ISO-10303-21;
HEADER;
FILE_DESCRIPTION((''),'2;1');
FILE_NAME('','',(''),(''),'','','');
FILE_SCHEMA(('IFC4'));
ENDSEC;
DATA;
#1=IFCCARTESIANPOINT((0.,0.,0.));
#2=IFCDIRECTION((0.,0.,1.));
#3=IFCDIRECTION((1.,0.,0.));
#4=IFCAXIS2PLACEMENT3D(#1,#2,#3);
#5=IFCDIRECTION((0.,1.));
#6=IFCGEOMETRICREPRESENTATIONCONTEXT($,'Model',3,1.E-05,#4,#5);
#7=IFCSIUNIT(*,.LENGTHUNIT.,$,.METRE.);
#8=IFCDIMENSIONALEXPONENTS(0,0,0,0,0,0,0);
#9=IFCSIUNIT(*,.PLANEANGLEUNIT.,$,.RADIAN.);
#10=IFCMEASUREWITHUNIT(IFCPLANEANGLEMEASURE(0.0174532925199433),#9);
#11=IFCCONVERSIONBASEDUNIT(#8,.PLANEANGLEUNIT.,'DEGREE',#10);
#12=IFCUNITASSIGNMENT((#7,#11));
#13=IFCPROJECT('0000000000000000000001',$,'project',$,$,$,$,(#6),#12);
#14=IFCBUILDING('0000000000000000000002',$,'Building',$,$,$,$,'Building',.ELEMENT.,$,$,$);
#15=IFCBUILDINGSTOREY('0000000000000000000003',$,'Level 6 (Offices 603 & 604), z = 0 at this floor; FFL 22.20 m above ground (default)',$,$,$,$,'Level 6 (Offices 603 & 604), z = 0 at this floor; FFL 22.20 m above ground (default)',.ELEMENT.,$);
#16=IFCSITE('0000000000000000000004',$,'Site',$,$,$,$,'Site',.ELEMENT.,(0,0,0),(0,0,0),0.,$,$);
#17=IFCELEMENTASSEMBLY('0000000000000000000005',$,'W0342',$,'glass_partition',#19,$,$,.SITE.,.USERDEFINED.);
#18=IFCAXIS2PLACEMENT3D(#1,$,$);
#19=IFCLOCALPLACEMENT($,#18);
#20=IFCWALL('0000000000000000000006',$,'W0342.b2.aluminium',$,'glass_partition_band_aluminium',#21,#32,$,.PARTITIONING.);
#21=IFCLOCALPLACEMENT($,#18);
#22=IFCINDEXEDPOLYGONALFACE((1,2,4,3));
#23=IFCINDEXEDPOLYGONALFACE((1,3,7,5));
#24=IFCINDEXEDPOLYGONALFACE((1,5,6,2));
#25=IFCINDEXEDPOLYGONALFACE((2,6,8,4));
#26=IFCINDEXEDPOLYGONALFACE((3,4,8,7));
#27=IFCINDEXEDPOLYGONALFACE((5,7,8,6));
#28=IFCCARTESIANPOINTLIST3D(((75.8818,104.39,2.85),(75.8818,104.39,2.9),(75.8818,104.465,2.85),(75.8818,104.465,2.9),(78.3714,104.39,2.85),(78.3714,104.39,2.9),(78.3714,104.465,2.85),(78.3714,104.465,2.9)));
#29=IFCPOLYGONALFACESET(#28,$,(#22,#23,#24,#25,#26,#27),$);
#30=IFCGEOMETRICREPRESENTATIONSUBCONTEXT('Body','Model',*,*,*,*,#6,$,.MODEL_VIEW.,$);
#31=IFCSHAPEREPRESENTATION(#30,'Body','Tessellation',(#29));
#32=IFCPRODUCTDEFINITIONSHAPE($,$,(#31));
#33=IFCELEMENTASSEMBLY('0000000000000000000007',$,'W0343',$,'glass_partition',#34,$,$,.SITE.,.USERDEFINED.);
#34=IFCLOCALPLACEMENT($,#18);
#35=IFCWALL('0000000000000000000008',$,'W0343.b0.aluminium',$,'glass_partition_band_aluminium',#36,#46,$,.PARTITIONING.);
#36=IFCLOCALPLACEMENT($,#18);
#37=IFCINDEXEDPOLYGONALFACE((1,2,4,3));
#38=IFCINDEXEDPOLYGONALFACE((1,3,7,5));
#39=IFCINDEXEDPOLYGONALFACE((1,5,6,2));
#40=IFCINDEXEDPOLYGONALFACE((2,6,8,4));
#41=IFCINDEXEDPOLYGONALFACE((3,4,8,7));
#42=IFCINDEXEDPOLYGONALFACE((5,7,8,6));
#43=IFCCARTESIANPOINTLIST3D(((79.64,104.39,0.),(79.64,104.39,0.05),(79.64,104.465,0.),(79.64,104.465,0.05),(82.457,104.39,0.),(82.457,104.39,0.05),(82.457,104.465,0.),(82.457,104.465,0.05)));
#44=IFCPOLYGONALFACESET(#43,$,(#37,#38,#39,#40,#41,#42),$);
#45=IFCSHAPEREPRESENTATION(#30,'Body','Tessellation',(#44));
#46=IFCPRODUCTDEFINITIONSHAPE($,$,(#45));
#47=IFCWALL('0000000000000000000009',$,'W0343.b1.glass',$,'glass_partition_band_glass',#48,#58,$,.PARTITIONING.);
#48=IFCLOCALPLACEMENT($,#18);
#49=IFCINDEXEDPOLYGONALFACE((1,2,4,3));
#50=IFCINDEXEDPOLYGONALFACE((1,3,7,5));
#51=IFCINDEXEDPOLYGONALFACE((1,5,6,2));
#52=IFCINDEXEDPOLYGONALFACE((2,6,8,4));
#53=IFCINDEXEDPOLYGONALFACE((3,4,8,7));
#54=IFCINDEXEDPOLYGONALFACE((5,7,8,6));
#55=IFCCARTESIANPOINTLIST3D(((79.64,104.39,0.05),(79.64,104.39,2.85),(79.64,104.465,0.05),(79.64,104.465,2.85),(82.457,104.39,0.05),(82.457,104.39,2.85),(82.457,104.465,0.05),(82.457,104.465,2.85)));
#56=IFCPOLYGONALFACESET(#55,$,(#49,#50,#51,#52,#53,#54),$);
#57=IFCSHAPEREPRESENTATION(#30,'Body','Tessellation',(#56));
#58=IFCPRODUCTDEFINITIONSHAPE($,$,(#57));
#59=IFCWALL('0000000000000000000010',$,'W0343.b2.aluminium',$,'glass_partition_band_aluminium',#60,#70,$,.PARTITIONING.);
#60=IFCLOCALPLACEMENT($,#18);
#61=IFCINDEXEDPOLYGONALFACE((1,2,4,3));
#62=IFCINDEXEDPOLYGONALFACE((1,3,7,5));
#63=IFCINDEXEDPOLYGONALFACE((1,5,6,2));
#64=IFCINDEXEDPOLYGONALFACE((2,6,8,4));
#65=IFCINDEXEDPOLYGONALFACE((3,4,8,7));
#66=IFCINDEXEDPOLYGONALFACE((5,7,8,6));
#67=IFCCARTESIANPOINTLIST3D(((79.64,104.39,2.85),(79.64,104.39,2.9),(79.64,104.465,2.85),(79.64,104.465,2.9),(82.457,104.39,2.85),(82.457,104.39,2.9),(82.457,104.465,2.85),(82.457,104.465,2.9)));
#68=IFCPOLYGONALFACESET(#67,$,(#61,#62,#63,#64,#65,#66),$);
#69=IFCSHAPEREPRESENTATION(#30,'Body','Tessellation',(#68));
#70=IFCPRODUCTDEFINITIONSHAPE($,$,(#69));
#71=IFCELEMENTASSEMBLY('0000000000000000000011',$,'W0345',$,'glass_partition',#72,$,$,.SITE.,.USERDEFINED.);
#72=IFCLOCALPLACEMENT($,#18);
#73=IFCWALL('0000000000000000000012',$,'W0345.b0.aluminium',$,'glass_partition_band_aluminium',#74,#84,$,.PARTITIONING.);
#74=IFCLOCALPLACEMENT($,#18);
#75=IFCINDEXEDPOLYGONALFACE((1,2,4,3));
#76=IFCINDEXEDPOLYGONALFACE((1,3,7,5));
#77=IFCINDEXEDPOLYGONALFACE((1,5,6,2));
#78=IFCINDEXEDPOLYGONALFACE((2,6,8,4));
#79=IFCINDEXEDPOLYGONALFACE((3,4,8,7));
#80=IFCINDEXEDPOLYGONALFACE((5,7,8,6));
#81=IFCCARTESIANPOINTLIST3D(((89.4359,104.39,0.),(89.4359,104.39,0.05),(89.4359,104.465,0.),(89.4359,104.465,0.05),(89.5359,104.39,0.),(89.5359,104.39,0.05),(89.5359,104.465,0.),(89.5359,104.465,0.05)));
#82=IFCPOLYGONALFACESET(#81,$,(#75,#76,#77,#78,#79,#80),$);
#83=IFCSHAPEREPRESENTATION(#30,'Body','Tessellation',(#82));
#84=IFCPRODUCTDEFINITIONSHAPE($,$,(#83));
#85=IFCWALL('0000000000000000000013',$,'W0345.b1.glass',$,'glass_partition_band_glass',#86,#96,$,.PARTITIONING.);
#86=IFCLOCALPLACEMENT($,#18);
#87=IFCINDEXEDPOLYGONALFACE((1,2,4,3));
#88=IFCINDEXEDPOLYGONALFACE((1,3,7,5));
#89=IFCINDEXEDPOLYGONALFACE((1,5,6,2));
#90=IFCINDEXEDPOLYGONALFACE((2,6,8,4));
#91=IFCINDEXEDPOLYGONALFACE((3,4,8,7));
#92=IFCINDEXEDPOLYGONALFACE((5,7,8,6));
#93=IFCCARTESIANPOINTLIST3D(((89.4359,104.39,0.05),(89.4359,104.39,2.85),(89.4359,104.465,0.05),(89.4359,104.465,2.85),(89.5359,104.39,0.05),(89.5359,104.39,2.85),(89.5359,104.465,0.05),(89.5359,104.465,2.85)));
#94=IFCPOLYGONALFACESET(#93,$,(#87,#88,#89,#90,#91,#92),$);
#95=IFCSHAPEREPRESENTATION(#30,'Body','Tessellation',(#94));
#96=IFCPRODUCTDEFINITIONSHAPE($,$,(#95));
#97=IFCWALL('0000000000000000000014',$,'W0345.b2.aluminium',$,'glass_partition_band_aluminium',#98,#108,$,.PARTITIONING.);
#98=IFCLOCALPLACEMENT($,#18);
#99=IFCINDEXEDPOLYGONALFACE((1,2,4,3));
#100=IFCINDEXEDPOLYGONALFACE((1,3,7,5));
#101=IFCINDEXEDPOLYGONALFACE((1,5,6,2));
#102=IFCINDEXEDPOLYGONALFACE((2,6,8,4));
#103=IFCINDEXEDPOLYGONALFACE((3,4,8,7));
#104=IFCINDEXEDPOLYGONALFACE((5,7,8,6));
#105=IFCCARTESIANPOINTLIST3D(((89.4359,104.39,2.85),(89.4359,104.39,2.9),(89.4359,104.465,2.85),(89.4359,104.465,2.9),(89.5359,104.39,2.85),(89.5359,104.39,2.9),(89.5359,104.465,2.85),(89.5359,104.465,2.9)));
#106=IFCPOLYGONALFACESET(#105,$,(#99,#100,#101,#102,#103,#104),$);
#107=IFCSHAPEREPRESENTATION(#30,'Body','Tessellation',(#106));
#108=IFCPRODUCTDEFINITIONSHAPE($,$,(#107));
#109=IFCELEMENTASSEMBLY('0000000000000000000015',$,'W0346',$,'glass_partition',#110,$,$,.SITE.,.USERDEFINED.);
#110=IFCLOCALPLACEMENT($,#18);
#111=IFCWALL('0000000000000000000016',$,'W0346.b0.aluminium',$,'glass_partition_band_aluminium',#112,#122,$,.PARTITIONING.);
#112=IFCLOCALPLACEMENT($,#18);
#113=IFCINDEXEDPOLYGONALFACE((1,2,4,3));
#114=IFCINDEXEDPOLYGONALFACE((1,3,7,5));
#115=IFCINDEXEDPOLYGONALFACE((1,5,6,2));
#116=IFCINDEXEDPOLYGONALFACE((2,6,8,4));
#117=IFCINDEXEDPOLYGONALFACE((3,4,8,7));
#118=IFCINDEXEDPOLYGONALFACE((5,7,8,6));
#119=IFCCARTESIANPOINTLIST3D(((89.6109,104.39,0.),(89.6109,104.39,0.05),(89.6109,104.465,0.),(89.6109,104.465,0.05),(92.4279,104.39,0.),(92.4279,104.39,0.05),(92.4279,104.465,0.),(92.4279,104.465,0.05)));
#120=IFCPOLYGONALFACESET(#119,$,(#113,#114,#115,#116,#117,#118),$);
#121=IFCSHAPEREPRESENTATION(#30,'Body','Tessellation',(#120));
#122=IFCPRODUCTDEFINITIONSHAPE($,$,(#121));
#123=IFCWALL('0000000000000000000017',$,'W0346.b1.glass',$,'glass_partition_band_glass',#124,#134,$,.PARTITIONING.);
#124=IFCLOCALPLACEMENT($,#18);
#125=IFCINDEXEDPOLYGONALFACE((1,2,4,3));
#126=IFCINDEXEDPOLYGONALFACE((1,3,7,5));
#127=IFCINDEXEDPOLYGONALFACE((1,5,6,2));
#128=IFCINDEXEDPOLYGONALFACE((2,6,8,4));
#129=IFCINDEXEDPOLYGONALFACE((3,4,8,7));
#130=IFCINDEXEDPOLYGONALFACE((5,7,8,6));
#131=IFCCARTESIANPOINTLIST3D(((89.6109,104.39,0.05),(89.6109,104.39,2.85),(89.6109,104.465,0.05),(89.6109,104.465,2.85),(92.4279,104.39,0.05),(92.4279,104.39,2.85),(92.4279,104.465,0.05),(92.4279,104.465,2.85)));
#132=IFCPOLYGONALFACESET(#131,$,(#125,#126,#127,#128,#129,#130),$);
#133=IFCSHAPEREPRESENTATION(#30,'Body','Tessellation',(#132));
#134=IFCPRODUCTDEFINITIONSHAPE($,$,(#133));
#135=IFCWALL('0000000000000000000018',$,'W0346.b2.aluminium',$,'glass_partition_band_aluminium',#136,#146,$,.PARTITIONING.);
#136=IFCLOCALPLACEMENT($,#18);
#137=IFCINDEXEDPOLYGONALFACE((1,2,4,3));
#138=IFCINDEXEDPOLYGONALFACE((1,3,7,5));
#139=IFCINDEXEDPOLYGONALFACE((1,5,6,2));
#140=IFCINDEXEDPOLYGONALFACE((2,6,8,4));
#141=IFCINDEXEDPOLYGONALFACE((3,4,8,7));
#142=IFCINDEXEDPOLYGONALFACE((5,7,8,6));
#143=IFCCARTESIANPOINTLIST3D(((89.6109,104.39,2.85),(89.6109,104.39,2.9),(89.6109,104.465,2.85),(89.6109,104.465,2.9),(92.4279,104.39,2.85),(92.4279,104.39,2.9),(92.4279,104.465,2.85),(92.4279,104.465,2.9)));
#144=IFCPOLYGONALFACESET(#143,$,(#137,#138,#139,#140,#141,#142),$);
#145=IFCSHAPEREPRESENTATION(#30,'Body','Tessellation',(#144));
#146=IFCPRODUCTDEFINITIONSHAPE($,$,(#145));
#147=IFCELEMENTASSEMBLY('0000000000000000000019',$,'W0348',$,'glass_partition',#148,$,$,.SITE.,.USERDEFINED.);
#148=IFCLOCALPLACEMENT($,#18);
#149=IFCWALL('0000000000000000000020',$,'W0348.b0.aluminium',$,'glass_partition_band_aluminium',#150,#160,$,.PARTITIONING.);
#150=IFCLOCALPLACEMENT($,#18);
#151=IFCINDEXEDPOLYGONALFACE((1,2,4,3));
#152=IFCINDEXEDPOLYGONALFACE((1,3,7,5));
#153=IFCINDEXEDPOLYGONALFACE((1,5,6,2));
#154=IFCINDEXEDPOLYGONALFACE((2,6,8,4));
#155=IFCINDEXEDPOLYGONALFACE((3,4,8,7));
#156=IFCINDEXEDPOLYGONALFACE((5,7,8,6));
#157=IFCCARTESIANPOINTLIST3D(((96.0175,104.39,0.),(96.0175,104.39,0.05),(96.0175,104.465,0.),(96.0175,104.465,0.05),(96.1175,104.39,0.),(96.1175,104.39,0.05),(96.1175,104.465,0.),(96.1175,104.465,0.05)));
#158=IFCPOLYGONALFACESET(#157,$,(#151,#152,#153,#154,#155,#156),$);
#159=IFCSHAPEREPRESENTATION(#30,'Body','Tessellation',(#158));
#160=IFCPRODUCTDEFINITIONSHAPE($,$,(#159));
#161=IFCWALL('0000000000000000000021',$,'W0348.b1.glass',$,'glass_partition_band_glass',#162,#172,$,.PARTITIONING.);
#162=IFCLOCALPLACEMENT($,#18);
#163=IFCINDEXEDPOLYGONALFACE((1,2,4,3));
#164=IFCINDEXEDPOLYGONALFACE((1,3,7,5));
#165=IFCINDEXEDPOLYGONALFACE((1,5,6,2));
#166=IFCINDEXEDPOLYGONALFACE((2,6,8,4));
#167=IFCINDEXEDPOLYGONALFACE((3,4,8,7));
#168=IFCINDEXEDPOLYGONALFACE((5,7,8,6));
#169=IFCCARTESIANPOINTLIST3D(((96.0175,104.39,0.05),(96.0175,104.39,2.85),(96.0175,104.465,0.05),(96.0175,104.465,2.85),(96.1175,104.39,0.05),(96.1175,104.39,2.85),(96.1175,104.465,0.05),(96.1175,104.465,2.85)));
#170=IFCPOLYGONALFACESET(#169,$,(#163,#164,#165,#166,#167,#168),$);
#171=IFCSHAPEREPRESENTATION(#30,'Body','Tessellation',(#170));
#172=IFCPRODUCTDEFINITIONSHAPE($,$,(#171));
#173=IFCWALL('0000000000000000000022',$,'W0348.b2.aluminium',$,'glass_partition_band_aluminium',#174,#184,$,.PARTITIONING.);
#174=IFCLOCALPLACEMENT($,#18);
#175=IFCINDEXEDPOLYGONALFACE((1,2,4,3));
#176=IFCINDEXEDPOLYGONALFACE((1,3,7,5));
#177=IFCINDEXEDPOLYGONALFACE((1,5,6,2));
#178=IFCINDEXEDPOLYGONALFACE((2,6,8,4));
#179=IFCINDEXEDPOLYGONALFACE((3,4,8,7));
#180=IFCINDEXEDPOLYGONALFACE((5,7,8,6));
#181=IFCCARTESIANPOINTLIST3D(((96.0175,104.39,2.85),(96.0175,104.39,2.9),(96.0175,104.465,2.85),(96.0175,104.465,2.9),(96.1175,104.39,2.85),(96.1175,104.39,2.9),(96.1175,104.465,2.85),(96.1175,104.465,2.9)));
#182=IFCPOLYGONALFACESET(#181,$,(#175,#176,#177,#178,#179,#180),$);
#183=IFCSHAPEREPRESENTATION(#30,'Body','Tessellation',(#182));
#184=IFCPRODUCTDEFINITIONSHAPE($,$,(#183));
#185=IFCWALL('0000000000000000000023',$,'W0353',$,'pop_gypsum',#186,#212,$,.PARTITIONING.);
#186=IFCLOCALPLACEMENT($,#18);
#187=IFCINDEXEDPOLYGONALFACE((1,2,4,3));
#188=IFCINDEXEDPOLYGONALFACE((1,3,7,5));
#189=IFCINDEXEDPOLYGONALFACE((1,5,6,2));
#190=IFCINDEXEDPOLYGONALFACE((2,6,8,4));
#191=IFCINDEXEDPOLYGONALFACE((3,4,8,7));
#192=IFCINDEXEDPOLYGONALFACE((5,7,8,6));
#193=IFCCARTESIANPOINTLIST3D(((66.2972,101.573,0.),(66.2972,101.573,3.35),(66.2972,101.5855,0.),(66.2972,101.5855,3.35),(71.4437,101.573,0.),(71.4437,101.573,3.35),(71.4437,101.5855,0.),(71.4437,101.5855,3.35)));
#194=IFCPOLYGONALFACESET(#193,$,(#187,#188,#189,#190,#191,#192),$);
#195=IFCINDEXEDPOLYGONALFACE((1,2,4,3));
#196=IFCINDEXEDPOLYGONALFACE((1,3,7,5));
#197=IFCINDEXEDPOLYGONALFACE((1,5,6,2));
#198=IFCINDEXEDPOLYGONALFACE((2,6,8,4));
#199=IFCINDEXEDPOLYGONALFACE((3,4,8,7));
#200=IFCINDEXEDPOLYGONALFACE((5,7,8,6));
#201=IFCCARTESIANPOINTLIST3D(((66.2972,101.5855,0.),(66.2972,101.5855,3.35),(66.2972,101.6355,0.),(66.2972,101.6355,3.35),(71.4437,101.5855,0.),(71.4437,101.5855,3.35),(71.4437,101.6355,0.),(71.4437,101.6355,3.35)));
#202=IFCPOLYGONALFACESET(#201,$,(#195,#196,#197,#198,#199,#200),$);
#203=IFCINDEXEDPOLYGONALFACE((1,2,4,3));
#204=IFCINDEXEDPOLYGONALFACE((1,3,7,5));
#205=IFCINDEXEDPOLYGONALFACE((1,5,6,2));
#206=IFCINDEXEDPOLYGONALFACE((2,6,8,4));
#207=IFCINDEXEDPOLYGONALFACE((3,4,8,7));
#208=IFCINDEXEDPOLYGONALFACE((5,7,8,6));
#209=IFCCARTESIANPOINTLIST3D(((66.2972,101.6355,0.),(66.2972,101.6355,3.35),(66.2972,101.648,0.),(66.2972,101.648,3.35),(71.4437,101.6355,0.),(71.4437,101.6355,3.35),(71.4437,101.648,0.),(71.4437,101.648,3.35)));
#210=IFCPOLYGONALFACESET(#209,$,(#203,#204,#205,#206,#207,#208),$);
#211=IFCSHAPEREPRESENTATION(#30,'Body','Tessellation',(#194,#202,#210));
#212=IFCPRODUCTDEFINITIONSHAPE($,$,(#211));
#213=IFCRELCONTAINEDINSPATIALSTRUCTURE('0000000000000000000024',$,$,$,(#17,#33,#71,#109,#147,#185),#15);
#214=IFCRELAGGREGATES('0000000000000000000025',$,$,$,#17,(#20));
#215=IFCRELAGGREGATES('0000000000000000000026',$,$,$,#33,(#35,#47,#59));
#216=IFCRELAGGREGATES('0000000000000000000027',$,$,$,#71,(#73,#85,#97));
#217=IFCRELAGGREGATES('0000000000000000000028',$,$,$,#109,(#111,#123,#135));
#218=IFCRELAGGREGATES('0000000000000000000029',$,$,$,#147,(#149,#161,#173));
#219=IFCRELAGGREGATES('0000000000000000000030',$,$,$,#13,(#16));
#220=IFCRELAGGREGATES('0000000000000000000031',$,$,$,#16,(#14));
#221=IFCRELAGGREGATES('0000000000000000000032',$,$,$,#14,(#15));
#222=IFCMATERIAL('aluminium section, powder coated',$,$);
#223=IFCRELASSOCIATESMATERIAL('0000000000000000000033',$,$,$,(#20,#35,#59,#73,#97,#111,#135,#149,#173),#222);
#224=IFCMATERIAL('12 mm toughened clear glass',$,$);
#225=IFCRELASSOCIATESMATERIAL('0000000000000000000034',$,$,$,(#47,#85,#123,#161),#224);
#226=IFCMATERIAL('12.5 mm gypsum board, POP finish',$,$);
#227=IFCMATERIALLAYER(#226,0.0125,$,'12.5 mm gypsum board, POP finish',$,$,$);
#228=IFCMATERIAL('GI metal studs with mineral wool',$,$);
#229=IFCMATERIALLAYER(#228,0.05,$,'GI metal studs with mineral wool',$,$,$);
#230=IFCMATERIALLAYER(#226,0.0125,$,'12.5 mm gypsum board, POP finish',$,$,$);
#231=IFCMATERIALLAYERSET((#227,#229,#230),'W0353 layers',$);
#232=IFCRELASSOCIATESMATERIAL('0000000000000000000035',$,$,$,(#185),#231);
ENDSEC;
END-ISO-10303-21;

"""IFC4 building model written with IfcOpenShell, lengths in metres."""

from ifc_helpers import new_model, entity, si_unit, converted_unit, direction, frame, frame_2d, origin_with_axes, place, context, subcontext, project, spatial, rectangle, extrude, material, layer, layer_set, layer_usage, element, aggregate, save


model = new_model("IFC4")

# Units and contexts
model_context = context("Model", 3, precision=1e-05, world=origin_with_axes(), true_north=direction((0.0, 1.0)))
body_context = subcontext(model_context, "Body", "Model", "MODEL_VIEW")
ifc_project = project(units=[si_unit("LENGTHUNIT", "METRE"), converted_unit("PLANEANGLEUNIT", "DEGREE", entity("IfcPlaneAngleMeasure", 0.0174532925199433), si_unit("PLANEANGLEUNIT", "RADIAN"), dimensions=[0, 0, 0, 0, 0, 0, 0])], contexts=[model_context])

# Site, building, storey
site = spatial("IfcSite", under=ifc_project, Name="Site", LongName="Site", CompositionType="ELEMENT", RefLatitude=(0, 0, 0), RefLongitude=(0, 0, 0), RefElevation=0.0)
building = spatial("IfcBuilding", under=site, Name="Building", LongName="Building", CompositionType="ELEMENT")
storey = spatial("IfcBuildingStorey", under=building, Name="Level 6 (Offices 603 & 604), z = 0 at this floor; FFL 22.20 m above ground (default)", LongName="Level 6 (Offices 603 & 604), z = 0 at this floor; FFL 22.20 m above ground (default)", CompositionType="ELEMENT")

# Element assembly, wall
assembly_1 = element("IfcElementAssembly", 1, inside=storey, Name="W0342", ObjectType="glass_partition", AssemblyPlace="SITE", PredefinedType="USERDEFINED")
ifc_material_1 = material(Name="aluminium section, powder coated")
placement = place(None, origin_with_axes())
wall_1 = element("IfcWall", 2, at=placement, material=ifc_material_1, Name="W0342.b2.aluminium", ObjectType="glass_partition_band_aluminium", PredefinedType="PARTITIONING", context=body_context, shape_type="SweptSolid", body=[
    extrude(rectangle(XDim=2.4896, YDim=0.075, at=frame_2d((0.0, 0.0), x_axis=(1.0, 0.0))), frame((77.1266, 104.4275, 2.85), z_axis=(0.0, 0.0, 1.0), x_axis=(1.0, 0.0, 0.0)), (0.0, 0.0, 1.0), 0.05),
])
aggregate(assembly_1, [wall_1])

# Element assemblies, walls
assembly_2 = element("IfcElementAssembly", 3, inside=storey, Name="W0343", ObjectType="glass_partition", AssemblyPlace="SITE", PredefinedType="USERDEFINED")
wall_2 = element("IfcWall", 4, at=placement, material=ifc_material_1, Name="W0343.b0.aluminium", ObjectType="glass_partition_band_aluminium", PredefinedType="PARTITIONING", context=body_context, shape_type="SweptSolid", body=[
    extrude(rectangle(XDim=2.817, YDim=0.075, at=frame_2d((0.0, 0.0), x_axis=(1.0, 0.0))), frame((81.0485, 104.4275, 0.0), z_axis=(0.0, 0.0, 1.0), x_axis=(1.0, 0.0, 0.0)), (0.0, 0.0, 1.0), 0.05),
])
ifc_material_2 = material(Name="12 mm toughened clear glass")
wall_3 = element("IfcWall", 5, at=placement, material=ifc_material_2, Name="W0343.b1.glass", ObjectType="glass_partition_band_glass", PredefinedType="PARTITIONING", context=body_context, shape_type="SweptSolid", body=[
    extrude(rectangle(XDim=2.817, YDim=0.075, at=frame_2d((0.0, 0.0), x_axis=(1.0, 0.0))), frame((81.0485, 104.4275, 0.05), z_axis=(0.0, 0.0, 1.0), x_axis=(1.0, 0.0, 0.0)), (0.0, 0.0, 1.0), 2.8),
])
wall_4 = element("IfcWall", 6, at=placement, material=ifc_material_1, Name="W0343.b2.aluminium", ObjectType="glass_partition_band_aluminium", PredefinedType="PARTITIONING", context=body_context, shape_type="SweptSolid", body=[
    extrude(rectangle(XDim=2.817, YDim=0.075, at=frame_2d((0.0, 0.0), x_axis=(1.0, 0.0))), frame((81.0485, 104.4275, 2.85), z_axis=(0.0, 0.0, 1.0), x_axis=(1.0, 0.0, 0.0)), (0.0, 0.0, 1.0), 0.05),
])
aggregate(assembly_2, [wall_2, wall_3, wall_4])
assembly_3 = element("IfcElementAssembly", 7, inside=storey, Name="W0345", ObjectType="glass_partition", AssemblyPlace="SITE", PredefinedType="USERDEFINED")
wall_5 = element("IfcWall", 8, at=placement, material=ifc_material_1, Name="W0345.b0.aluminium", ObjectType="glass_partition_band_aluminium", PredefinedType="PARTITIONING", context=body_context, shape_type="SweptSolid", body=[
    extrude(rectangle(XDim=0.1, YDim=0.075, at=frame_2d((0.0, 0.0), x_axis=(1.0, 0.0))), frame((89.4859, 104.4275, 0.0), z_axis=(0.0, 0.0, 1.0), x_axis=(1.0, 0.0, 0.0)), (0.0, 0.0, 1.0), 0.05),
])
wall_6 = element("IfcWall", 9, at=placement, material=ifc_material_2, Name="W0345.b1.glass", ObjectType="glass_partition_band_glass", PredefinedType="PARTITIONING", context=body_context, shape_type="SweptSolid", body=[
    extrude(rectangle(XDim=0.1, YDim=0.075, at=frame_2d((0.0, 0.0), x_axis=(1.0, 0.0))), frame((89.4859, 104.4275, 0.05), z_axis=(0.0, 0.0, 1.0), x_axis=(1.0, 0.0, 0.0)), (0.0, 0.0, 1.0), 2.8),
])
wall_7 = element("IfcWall", 10, at=placement, material=ifc_material_1, Name="W0345.b2.aluminium", ObjectType="glass_partition_band_aluminium", PredefinedType="PARTITIONING", context=body_context, shape_type="SweptSolid", body=[
    extrude(rectangle(XDim=0.1, YDim=0.075, at=frame_2d((0.0, 0.0), x_axis=(1.0, 0.0))), frame((89.4859, 104.4275, 2.85), z_axis=(0.0, 0.0, 1.0), x_axis=(1.0, 0.0, 0.0)), (0.0, 0.0, 1.0), 0.05),
])
aggregate(assembly_3, [wall_5, wall_6, wall_7])
assembly_4 = element("IfcElementAssembly", 11, inside=storey, Name="W0346", ObjectType="glass_partition", AssemblyPlace="SITE", PredefinedType="USERDEFINED")
wall_8 = element("IfcWall", 12, at=placement, material=ifc_material_1, Name="W0346.b0.aluminium", ObjectType="glass_partition_band_aluminium", PredefinedType="PARTITIONING", context=body_context, shape_type="SweptSolid", body=[
    extrude(rectangle(XDim=2.817, YDim=0.075, at=frame_2d((0.0, 0.0), x_axis=(1.0, 0.0))), frame((91.0194, 104.4275, 0.0), z_axis=(0.0, 0.0, 1.0), x_axis=(1.0, 0.0, 0.0)), (0.0, 0.0, 1.0), 0.05),
])
wall_9 = element("IfcWall", 13, at=placement, material=ifc_material_2, Name="W0346.b1.glass", ObjectType="glass_partition_band_glass", PredefinedType="PARTITIONING", context=body_context, shape_type="SweptSolid", body=[
    extrude(rectangle(XDim=2.817, YDim=0.075, at=frame_2d((0.0, 0.0), x_axis=(1.0, 0.0))), frame((91.0194, 104.4275, 0.05), z_axis=(0.0, 0.0, 1.0), x_axis=(1.0, 0.0, 0.0)), (0.0, 0.0, 1.0), 2.8),
])
wall_10 = element("IfcWall", 14, at=placement, material=ifc_material_1, Name="W0346.b2.aluminium", ObjectType="glass_partition_band_aluminium", PredefinedType="PARTITIONING", context=body_context, shape_type="SweptSolid", body=[
    extrude(rectangle(XDim=2.817, YDim=0.075, at=frame_2d((0.0, 0.0), x_axis=(1.0, 0.0))), frame((91.0194, 104.4275, 2.85), z_axis=(0.0, 0.0, 1.0), x_axis=(1.0, 0.0, 0.0)), (0.0, 0.0, 1.0), 0.05),
])
aggregate(assembly_4, [wall_8, wall_9, wall_10])
assembly_5 = element("IfcElementAssembly", 15, inside=storey, Name="W0348", ObjectType="glass_partition", AssemblyPlace="SITE", PredefinedType="USERDEFINED")
wall_11 = element("IfcWall", 16, at=placement, material=ifc_material_1, Name="W0348.b0.aluminium", ObjectType="glass_partition_band_aluminium", PredefinedType="PARTITIONING", context=body_context, shape_type="SweptSolid", body=[
    extrude(rectangle(XDim=0.1, YDim=0.075, at=frame_2d((0.0, 0.0), x_axis=(1.0, 0.0))), frame((96.0675, 104.4275, 0.0), z_axis=(0.0, 0.0, 1.0), x_axis=(1.0, 0.0, 0.0)), (0.0, 0.0, 1.0), 0.05),
])
wall_12 = element("IfcWall", 17, at=placement, material=ifc_material_2, Name="W0348.b1.glass", ObjectType="glass_partition_band_glass", PredefinedType="PARTITIONING", context=body_context, shape_type="SweptSolid", body=[
    extrude(rectangle(XDim=0.1, YDim=0.075, at=frame_2d((0.0, 0.0), x_axis=(1.0, 0.0))), frame((96.0675, 104.4275, 0.05), z_axis=(0.0, 0.0, 1.0), x_axis=(1.0, 0.0, 0.0)), (0.0, 0.0, 1.0), 2.8),
])
wall_13 = element("IfcWall", 18, at=placement, material=ifc_material_1, Name="W0348.b2.aluminium", ObjectType="glass_partition_band_aluminium", PredefinedType="PARTITIONING", context=body_context, shape_type="SweptSolid", body=[
    extrude(rectangle(XDim=0.1, YDim=0.075, at=frame_2d((0.0, 0.0), x_axis=(1.0, 0.0))), frame((96.0675, 104.4275, 2.85), z_axis=(0.0, 0.0, 1.0), x_axis=(1.0, 0.0, 0.0)), (0.0, 0.0, 1.0), 0.05),
])
aggregate(assembly_5, [wall_11, wall_12, wall_13])

# Wall
ifc_material_3 = material(Name="12.5 mm gypsum board, POP finish")
ifc_layer_1 = layer(ifc_material_3, 0.0125, Name="12.5 mm gypsum board, POP finish")
ifc_material_4 = material(Name="GI metal studs with mineral wool")
ifc_layer_2 = layer(ifc_material_4, 0.05, Name="GI metal studs with mineral wool")
ifc_layer_3 = layer(ifc_material_3, 0.0125, Name="12.5 mm gypsum board, POP finish")
ifc_layer_set_1 = layer_set([ifc_layer_1, ifc_layer_2, ifc_layer_3], Name="W0353 layers")
ifc_layer_usage_1 = layer_usage(ifc_layer_set_1, "AXIS2", "POSITIVE", -0.0375)
element("IfcWall", 19, at=placement, inside=storey, material=ifc_layer_usage_1, Name="W0353", ObjectType="pop_gypsum", PredefinedType="PARTITIONING", context=body_context, shape_type="SweptSolid", body=[
    extrude(rectangle(XDim=5.1465, YDim=0.0125, at=frame_2d((0.0, 0.0), x_axis=(1.0, 0.0))), frame((68.8705, 101.5793, 0.0), z_axis=(0.0, 0.0, 1.0), x_axis=(1.0, 0.0, 0.0)), (0.0, 0.0, 1.0), 3.35),
    extrude(rectangle(XDim=5.1465, YDim=0.05, at=frame_2d((0.0, 0.0313), x_axis=(1.0, 0.0))), frame((68.8705, 101.5793, 0.0), z_axis=(0.0, 0.0, 1.0), x_axis=(1.0, 0.0, 0.0)), (0.0, 0.0, 1.0), 3.35),
    extrude(rectangle(XDim=5.1465, YDim=0.0125, at=frame_2d((0.0, 0.0625), x_axis=(1.0, 0.0))), frame((68.8705, 101.5793, 0.0), z_axis=(0.0, 0.0, 1.0), x_axis=(1.0, 0.0, 0.0)), (0.0, 0.0, 1.0), 3.35),
])

save(model, "model.ifc")
